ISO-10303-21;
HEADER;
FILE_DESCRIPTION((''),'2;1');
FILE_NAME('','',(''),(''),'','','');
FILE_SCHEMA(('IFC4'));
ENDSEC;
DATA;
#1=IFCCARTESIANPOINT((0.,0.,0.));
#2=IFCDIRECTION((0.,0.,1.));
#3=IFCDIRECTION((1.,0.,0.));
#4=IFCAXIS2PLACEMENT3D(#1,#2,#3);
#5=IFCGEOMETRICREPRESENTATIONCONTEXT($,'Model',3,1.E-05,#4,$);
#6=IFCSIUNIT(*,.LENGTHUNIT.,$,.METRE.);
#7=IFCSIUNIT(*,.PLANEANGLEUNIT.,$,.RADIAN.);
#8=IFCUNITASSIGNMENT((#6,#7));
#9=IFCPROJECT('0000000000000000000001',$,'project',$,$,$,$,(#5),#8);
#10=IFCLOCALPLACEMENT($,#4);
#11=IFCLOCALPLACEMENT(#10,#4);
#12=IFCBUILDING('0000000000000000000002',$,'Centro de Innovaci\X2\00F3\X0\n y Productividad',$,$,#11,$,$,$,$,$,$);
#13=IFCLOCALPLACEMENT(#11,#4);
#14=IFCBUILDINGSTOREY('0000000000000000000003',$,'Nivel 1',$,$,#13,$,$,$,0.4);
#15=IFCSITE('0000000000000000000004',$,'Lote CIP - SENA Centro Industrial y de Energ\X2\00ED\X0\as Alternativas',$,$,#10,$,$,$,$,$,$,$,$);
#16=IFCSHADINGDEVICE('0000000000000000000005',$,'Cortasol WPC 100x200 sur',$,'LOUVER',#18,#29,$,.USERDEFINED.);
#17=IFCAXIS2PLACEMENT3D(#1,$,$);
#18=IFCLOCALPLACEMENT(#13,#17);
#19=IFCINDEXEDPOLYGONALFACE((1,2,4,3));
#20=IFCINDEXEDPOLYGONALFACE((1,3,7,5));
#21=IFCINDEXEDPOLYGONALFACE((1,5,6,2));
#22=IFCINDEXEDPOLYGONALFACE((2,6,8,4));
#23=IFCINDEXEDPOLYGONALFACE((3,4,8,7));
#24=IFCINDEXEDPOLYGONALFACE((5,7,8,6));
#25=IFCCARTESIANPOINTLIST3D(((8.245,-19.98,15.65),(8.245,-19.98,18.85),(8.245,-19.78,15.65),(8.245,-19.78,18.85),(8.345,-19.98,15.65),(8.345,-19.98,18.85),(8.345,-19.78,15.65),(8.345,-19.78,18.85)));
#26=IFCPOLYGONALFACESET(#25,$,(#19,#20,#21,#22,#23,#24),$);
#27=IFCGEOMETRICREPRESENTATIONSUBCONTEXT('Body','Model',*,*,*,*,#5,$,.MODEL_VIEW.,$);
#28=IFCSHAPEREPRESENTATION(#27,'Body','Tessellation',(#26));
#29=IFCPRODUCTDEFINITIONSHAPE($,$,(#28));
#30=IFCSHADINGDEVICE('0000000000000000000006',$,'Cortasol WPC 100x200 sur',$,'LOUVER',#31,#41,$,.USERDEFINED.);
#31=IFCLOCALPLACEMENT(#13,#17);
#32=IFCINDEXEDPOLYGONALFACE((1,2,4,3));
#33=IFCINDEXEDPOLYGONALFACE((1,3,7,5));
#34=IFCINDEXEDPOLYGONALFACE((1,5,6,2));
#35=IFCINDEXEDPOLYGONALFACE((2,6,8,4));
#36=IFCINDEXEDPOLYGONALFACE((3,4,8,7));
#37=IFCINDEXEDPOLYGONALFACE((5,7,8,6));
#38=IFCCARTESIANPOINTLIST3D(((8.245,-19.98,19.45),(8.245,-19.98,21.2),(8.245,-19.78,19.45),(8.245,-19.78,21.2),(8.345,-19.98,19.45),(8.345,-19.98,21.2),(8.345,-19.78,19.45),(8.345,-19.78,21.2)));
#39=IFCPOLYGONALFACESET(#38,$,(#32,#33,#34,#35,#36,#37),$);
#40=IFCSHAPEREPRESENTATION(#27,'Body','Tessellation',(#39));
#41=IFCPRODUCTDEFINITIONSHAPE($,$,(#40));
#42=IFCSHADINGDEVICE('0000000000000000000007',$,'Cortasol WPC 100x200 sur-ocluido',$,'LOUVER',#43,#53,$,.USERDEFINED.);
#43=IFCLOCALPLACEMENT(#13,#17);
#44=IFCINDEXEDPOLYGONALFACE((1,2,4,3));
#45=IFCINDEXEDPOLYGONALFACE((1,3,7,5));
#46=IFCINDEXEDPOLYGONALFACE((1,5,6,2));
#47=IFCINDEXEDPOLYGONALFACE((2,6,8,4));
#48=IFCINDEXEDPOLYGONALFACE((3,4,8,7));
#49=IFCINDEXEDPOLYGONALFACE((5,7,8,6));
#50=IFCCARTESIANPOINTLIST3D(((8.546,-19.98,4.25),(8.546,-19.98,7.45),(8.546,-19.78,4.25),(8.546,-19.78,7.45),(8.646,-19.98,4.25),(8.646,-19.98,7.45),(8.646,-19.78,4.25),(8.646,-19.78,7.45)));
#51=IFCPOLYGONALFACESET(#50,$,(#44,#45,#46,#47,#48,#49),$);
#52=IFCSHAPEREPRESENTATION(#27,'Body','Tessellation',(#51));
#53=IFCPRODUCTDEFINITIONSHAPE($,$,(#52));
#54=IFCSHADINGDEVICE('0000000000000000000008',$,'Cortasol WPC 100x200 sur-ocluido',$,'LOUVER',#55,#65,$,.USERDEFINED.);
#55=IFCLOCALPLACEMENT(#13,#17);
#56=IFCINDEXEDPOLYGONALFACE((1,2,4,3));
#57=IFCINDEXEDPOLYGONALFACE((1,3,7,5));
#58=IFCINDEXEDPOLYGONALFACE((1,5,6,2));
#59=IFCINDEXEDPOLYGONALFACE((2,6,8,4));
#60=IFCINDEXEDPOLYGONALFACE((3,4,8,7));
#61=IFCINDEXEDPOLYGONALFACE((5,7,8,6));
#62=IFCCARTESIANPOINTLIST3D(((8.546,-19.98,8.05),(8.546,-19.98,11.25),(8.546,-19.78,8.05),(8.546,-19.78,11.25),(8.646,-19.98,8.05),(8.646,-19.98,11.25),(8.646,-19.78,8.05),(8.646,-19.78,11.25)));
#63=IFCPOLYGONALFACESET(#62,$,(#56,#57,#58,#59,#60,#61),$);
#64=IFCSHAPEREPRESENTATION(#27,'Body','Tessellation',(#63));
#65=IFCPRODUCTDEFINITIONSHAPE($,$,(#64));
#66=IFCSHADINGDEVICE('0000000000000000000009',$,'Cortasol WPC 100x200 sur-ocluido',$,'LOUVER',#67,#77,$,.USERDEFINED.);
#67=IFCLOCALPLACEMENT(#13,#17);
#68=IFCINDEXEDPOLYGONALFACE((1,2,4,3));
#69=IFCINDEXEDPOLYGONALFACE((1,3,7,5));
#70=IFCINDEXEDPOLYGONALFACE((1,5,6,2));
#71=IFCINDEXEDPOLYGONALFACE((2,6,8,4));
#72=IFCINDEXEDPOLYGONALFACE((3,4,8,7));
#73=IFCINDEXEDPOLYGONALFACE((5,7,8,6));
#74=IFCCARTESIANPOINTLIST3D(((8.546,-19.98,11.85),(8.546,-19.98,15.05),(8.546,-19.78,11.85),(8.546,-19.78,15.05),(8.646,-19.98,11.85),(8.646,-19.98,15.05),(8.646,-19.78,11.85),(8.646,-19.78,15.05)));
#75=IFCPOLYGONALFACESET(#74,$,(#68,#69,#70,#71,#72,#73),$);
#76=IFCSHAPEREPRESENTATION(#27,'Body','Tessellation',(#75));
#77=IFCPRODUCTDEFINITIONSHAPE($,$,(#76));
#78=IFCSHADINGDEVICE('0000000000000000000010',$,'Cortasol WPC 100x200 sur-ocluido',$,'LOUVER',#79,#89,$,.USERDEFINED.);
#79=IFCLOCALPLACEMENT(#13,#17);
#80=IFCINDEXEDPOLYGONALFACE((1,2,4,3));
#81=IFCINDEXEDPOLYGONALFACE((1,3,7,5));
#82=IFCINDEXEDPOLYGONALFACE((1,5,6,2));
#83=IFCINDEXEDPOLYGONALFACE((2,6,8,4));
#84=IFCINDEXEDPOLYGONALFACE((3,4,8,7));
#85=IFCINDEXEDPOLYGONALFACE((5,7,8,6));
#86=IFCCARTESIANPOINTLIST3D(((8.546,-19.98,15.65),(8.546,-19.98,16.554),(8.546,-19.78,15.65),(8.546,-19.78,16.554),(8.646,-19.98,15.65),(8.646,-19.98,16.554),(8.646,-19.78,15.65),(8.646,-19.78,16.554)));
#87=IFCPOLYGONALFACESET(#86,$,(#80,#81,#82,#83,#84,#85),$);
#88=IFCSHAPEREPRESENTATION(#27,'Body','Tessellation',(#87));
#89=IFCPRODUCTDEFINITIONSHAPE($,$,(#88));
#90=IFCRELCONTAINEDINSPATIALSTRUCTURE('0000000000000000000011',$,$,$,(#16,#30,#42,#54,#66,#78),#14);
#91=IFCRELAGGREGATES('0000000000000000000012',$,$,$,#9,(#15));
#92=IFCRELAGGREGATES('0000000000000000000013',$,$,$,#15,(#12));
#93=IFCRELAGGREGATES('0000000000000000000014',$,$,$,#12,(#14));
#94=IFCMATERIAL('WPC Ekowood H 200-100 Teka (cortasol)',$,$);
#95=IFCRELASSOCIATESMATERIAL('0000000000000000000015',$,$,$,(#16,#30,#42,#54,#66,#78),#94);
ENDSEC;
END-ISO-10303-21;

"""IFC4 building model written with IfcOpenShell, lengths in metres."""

from ifc_helpers import new_model, si_unit, frame, origin_with_axes, place, context, subcontext, project, spatial, polyline, outline, extrude, material, element, save


model = new_model("IFC4")

# Units and contexts
model_context = context("Model", 3, precision=1e-05, world=origin_with_axes())
body_context = subcontext(model_context, "Body", "Model", "MODEL_VIEW")
ifc_project = project(units=[si_unit("LENGTHUNIT", "METRE"), si_unit("PLANEANGLEUNIT", "RADIAN")], contexts=[model_context])

# Site, building, storey
site_placement = place(None, origin_with_axes())
site = spatial("IfcSite", under=ifc_project, at=site_placement, Name="Lote CIP - SENA Centro Industrial y de Energías Alternativas")
building_placement = place(site_placement, origin_with_axes())
building = spatial("IfcBuilding", under=site, at=building_placement, Name="Centro de Innovación y Productividad")
storey_placement = place(building_placement, origin_with_axes())
storey = spatial("IfcBuildingStorey", under=building, at=storey_placement, Name="Nivel 1", Elevation=0.4)

# Shading devices
ifc_material_1 = material(Name="WPC Ekowood H 200-100 Teka (cortasol)")
shading_device_1_placement = place(storey_placement, origin_with_axes())
element("IfcShadingDevice", 1, at=shading_device_1_placement, inside=storey, material=ifc_material_1, Name="Cortasol WPC 100x200 sur", ObjectType="LOUVER", PredefinedType="USERDEFINED", context=body_context, shape_type="SweptSolid", body=[
    extrude(outline(polyline([(8.245, -19.98), (8.245, -19.78), (8.345, -19.78), (8.345, -19.98), (8.245, -19.98)])), frame((0.0, 0.0, 15.65)), (0.0, 0.0, 1.0), 3.2),
])
shading_device_2_placement = place(storey_placement, origin_with_axes())
element("IfcShadingDevice", 2, at=shading_device_2_placement, inside=storey, material=ifc_material_1, Name="Cortasol WPC 100x200 sur", ObjectType="LOUVER", PredefinedType="USERDEFINED", context=body_context, shape_type="SweptSolid", body=[
    extrude(outline(polyline([(8.245, -19.98), (8.245, -19.78), (8.345, -19.78), (8.345, -19.98), (8.245, -19.98)])), frame((0.0, 0.0, 19.45)), (0.0, 0.0, 1.0), 1.75),
])
shading_device_3_placement = place(storey_placement, origin_with_axes())
element("IfcShadingDevice", 3, at=shading_device_3_placement, inside=storey, material=ifc_material_1, Name="Cortasol WPC 100x200 sur-ocluido", ObjectType="LOUVER", PredefinedType="USERDEFINED", context=body_context, shape_type="SweptSolid", body=[
    extrude(outline(polyline([(8.546, -19.98), (8.546, -19.78), (8.646, -19.78), (8.646, -19.98), (8.546, -19.98)])), frame((0.0, 0.0, 4.25)), (0.0, 0.0, 1.0), 3.2),
])
shading_device_4_placement = place(storey_placement, origin_with_axes())
element("IfcShadingDevice", 4, at=shading_device_4_placement, inside=storey, material=ifc_material_1, Name="Cortasol WPC 100x200 sur-ocluido", ObjectType="LOUVER", PredefinedType="USERDEFINED", context=body_context, shape_type="SweptSolid", body=[
    extrude(outline(polyline([(8.546, -19.98), (8.546, -19.78), (8.646, -19.78), (8.646, -19.98), (8.546, -19.98)])), frame((0.0, 0.0, 8.05)), (0.0, 0.0, 1.0), 3.2),
])
shading_device_5_placement = place(storey_placement, origin_with_axes())
element("IfcShadingDevice", 5, at=shading_device_5_placement, inside=storey, material=ifc_material_1, Name="Cortasol WPC 100x200 sur-ocluido", ObjectType="LOUVER", PredefinedType="USERDEFINED", context=body_context, shape_type="SweptSolid", body=[
    extrude(outline(polyline([(8.546, -19.98), (8.546, -19.78), (8.646, -19.78), (8.646, -19.98), (8.546, -19.98)])), frame((0.0, 0.0, 11.85)), (0.0, 0.0, 1.0), 3.2),
])
shading_device_6_placement = place(storey_placement, origin_with_axes())
element("IfcShadingDevice", 6, at=shading_device_6_placement, inside=storey, material=ifc_material_1, Name="Cortasol WPC 100x200 sur-ocluido", ObjectType="LOUVER", PredefinedType="USERDEFINED", context=body_context, shape_type="SweptSolid", body=[
    extrude(outline(polyline([(8.546, -19.98), (8.546, -19.78), (8.646, -19.78), (8.646, -19.98), (8.546, -19.98)])), frame((0.0, 0.0, 15.65)), (0.0, 0.0, 1.0), 0.904),
])

save(model, "model.ifc")
